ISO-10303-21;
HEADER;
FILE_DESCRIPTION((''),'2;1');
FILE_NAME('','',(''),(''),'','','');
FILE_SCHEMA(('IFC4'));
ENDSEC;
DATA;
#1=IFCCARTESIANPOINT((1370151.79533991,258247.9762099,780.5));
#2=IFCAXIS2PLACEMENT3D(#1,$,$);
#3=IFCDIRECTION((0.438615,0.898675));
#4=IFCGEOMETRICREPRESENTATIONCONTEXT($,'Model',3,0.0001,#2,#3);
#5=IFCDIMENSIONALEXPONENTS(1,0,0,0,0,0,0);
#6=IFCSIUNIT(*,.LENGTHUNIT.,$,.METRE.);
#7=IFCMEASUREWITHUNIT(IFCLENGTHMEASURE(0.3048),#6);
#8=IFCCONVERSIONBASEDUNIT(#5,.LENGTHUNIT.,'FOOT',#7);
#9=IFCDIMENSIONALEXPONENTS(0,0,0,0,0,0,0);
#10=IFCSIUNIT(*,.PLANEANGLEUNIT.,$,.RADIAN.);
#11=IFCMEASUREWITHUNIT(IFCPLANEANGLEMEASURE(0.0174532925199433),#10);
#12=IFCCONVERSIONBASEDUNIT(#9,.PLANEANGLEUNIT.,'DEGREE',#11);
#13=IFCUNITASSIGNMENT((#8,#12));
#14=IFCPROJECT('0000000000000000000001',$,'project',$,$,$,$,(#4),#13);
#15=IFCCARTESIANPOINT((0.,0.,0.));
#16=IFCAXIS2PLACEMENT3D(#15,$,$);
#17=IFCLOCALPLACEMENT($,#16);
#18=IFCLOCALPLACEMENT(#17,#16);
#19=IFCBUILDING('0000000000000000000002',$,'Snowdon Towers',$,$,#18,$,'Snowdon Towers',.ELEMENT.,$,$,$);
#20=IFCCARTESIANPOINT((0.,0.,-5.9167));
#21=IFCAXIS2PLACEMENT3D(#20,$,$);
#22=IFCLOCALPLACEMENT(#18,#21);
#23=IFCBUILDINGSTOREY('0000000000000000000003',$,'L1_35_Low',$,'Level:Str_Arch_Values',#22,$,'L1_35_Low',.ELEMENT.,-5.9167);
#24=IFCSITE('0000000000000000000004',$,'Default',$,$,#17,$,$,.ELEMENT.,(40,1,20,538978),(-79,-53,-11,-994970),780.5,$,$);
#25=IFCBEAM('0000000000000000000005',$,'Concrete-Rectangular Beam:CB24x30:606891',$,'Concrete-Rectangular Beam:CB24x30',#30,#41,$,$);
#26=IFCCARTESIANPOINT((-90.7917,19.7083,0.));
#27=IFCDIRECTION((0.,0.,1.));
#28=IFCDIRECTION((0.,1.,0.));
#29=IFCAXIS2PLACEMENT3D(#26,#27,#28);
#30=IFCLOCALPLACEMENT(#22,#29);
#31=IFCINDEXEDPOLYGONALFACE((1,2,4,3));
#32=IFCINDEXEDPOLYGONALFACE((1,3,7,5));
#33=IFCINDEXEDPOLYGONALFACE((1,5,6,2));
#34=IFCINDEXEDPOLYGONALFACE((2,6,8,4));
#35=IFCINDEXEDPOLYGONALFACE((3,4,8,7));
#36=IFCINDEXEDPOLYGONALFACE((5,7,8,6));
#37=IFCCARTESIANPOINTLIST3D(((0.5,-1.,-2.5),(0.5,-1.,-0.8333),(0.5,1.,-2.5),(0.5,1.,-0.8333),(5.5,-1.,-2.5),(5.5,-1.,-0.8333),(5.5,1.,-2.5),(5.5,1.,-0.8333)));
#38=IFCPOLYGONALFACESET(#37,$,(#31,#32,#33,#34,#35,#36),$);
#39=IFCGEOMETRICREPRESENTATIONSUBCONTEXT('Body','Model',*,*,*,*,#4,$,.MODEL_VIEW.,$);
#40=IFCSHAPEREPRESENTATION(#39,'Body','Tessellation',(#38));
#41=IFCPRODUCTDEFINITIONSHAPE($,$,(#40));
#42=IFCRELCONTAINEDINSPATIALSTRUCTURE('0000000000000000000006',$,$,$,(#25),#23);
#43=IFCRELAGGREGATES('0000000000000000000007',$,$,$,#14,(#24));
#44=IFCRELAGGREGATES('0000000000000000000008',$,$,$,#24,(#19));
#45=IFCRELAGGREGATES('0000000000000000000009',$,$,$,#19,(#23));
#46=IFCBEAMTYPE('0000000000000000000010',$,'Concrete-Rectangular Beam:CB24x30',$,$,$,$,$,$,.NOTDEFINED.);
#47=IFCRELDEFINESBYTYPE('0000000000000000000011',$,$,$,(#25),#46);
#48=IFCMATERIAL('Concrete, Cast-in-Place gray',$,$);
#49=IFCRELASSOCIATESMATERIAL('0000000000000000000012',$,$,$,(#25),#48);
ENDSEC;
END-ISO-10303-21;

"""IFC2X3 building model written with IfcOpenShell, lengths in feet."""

from ifc_helpers import new_model, entity, si_unit, converted_unit, direction, frame, frame_2d, origin, place, context, subcontext, project, spatial, rectangle, extrude, material, type_object, element, save


model = new_model("IFC2X3")

# Units and contexts
model_context = context("Model", 3, precision=0.0001, world=frame((1370151.79533991, 258247.9762099, 780.5)), true_north=direction((0.438615, 0.898675)))
body_context = subcontext(model_context, "Body", "Model", "MODEL_VIEW")
ifc_project = project(units=[converted_unit("LENGTHUNIT", "FOOT", entity("IfcLengthMeasure", 0.3048), si_unit("LENGTHUNIT", "METRE"), dimensions=[1, 0, 0, 0, 0, 0, 0]), converted_unit("PLANEANGLEUNIT", "DEGREE", entity("IfcPlaneAngleMeasure", 0.0174532925199433), si_unit("PLANEANGLEUNIT", "RADIAN"), dimensions=[0, 0, 0, 0, 0, 0, 0])], contexts=[model_context])

# Site, building, storey
site_placement = place(None, origin())
site = spatial("IfcSite", under=ifc_project, at=site_placement, Name="Default", CompositionType="ELEMENT", RefLatitude=(40, 1, 20, 538978), RefLongitude=(-79, -53, -11, -994970), RefElevation=780.5)
building_placement = place(site_placement, origin())
building = spatial("IfcBuilding", under=site, at=building_placement, Name="Snowdon Towers", LongName="Snowdon Towers", CompositionType="ELEMENT")
storey_placement = place(building_placement, frame((0.0, 0.0, -5.9167)))
storey = spatial("IfcBuildingStorey", under=building, at=storey_placement, Name="L1_35_Low", ObjectType="Level:Str_Arch_Values", LongName="L1_35_Low", CompositionType="ELEMENT", Elevation=-5.9167)

# Beam
ifc_material = material(Name="Concrete, Cast-in-Place gray")
beam_type = type_object("IfcBeamType", Name="Concrete-Rectangular Beam:CB24x30", PredefinedType="NOTDEFINED")
beam_placement = place(storey_placement, frame((-90.7917, 19.7083, 0.0), z_axis=(0.0, 0.0, 1.0), x_axis=(0.0, 1.0, 0.0)))
element("IfcBeam", 1, at=beam_placement, inside=storey, type_object=beam_type, material=ifc_material, Name="Concrete-Rectangular Beam:CB24x30:606891", ObjectType="Concrete-Rectangular Beam:CB24x30", context=body_context, shape_type="SweptSolid", body=[
    extrude(rectangle(XDim=1.6667, YDim=2.0, at=frame_2d((0.0, 0.0), x_axis=(1.0, 0.0))), frame((0.5, 0.0, -1.6667), z_axis=(1.0, 0.0, 0.0), x_axis=(0.0, 0.0, -1.0)), (0.0, 0.0, 1.0), 5.0),
])

save(model, "model.ifc")
